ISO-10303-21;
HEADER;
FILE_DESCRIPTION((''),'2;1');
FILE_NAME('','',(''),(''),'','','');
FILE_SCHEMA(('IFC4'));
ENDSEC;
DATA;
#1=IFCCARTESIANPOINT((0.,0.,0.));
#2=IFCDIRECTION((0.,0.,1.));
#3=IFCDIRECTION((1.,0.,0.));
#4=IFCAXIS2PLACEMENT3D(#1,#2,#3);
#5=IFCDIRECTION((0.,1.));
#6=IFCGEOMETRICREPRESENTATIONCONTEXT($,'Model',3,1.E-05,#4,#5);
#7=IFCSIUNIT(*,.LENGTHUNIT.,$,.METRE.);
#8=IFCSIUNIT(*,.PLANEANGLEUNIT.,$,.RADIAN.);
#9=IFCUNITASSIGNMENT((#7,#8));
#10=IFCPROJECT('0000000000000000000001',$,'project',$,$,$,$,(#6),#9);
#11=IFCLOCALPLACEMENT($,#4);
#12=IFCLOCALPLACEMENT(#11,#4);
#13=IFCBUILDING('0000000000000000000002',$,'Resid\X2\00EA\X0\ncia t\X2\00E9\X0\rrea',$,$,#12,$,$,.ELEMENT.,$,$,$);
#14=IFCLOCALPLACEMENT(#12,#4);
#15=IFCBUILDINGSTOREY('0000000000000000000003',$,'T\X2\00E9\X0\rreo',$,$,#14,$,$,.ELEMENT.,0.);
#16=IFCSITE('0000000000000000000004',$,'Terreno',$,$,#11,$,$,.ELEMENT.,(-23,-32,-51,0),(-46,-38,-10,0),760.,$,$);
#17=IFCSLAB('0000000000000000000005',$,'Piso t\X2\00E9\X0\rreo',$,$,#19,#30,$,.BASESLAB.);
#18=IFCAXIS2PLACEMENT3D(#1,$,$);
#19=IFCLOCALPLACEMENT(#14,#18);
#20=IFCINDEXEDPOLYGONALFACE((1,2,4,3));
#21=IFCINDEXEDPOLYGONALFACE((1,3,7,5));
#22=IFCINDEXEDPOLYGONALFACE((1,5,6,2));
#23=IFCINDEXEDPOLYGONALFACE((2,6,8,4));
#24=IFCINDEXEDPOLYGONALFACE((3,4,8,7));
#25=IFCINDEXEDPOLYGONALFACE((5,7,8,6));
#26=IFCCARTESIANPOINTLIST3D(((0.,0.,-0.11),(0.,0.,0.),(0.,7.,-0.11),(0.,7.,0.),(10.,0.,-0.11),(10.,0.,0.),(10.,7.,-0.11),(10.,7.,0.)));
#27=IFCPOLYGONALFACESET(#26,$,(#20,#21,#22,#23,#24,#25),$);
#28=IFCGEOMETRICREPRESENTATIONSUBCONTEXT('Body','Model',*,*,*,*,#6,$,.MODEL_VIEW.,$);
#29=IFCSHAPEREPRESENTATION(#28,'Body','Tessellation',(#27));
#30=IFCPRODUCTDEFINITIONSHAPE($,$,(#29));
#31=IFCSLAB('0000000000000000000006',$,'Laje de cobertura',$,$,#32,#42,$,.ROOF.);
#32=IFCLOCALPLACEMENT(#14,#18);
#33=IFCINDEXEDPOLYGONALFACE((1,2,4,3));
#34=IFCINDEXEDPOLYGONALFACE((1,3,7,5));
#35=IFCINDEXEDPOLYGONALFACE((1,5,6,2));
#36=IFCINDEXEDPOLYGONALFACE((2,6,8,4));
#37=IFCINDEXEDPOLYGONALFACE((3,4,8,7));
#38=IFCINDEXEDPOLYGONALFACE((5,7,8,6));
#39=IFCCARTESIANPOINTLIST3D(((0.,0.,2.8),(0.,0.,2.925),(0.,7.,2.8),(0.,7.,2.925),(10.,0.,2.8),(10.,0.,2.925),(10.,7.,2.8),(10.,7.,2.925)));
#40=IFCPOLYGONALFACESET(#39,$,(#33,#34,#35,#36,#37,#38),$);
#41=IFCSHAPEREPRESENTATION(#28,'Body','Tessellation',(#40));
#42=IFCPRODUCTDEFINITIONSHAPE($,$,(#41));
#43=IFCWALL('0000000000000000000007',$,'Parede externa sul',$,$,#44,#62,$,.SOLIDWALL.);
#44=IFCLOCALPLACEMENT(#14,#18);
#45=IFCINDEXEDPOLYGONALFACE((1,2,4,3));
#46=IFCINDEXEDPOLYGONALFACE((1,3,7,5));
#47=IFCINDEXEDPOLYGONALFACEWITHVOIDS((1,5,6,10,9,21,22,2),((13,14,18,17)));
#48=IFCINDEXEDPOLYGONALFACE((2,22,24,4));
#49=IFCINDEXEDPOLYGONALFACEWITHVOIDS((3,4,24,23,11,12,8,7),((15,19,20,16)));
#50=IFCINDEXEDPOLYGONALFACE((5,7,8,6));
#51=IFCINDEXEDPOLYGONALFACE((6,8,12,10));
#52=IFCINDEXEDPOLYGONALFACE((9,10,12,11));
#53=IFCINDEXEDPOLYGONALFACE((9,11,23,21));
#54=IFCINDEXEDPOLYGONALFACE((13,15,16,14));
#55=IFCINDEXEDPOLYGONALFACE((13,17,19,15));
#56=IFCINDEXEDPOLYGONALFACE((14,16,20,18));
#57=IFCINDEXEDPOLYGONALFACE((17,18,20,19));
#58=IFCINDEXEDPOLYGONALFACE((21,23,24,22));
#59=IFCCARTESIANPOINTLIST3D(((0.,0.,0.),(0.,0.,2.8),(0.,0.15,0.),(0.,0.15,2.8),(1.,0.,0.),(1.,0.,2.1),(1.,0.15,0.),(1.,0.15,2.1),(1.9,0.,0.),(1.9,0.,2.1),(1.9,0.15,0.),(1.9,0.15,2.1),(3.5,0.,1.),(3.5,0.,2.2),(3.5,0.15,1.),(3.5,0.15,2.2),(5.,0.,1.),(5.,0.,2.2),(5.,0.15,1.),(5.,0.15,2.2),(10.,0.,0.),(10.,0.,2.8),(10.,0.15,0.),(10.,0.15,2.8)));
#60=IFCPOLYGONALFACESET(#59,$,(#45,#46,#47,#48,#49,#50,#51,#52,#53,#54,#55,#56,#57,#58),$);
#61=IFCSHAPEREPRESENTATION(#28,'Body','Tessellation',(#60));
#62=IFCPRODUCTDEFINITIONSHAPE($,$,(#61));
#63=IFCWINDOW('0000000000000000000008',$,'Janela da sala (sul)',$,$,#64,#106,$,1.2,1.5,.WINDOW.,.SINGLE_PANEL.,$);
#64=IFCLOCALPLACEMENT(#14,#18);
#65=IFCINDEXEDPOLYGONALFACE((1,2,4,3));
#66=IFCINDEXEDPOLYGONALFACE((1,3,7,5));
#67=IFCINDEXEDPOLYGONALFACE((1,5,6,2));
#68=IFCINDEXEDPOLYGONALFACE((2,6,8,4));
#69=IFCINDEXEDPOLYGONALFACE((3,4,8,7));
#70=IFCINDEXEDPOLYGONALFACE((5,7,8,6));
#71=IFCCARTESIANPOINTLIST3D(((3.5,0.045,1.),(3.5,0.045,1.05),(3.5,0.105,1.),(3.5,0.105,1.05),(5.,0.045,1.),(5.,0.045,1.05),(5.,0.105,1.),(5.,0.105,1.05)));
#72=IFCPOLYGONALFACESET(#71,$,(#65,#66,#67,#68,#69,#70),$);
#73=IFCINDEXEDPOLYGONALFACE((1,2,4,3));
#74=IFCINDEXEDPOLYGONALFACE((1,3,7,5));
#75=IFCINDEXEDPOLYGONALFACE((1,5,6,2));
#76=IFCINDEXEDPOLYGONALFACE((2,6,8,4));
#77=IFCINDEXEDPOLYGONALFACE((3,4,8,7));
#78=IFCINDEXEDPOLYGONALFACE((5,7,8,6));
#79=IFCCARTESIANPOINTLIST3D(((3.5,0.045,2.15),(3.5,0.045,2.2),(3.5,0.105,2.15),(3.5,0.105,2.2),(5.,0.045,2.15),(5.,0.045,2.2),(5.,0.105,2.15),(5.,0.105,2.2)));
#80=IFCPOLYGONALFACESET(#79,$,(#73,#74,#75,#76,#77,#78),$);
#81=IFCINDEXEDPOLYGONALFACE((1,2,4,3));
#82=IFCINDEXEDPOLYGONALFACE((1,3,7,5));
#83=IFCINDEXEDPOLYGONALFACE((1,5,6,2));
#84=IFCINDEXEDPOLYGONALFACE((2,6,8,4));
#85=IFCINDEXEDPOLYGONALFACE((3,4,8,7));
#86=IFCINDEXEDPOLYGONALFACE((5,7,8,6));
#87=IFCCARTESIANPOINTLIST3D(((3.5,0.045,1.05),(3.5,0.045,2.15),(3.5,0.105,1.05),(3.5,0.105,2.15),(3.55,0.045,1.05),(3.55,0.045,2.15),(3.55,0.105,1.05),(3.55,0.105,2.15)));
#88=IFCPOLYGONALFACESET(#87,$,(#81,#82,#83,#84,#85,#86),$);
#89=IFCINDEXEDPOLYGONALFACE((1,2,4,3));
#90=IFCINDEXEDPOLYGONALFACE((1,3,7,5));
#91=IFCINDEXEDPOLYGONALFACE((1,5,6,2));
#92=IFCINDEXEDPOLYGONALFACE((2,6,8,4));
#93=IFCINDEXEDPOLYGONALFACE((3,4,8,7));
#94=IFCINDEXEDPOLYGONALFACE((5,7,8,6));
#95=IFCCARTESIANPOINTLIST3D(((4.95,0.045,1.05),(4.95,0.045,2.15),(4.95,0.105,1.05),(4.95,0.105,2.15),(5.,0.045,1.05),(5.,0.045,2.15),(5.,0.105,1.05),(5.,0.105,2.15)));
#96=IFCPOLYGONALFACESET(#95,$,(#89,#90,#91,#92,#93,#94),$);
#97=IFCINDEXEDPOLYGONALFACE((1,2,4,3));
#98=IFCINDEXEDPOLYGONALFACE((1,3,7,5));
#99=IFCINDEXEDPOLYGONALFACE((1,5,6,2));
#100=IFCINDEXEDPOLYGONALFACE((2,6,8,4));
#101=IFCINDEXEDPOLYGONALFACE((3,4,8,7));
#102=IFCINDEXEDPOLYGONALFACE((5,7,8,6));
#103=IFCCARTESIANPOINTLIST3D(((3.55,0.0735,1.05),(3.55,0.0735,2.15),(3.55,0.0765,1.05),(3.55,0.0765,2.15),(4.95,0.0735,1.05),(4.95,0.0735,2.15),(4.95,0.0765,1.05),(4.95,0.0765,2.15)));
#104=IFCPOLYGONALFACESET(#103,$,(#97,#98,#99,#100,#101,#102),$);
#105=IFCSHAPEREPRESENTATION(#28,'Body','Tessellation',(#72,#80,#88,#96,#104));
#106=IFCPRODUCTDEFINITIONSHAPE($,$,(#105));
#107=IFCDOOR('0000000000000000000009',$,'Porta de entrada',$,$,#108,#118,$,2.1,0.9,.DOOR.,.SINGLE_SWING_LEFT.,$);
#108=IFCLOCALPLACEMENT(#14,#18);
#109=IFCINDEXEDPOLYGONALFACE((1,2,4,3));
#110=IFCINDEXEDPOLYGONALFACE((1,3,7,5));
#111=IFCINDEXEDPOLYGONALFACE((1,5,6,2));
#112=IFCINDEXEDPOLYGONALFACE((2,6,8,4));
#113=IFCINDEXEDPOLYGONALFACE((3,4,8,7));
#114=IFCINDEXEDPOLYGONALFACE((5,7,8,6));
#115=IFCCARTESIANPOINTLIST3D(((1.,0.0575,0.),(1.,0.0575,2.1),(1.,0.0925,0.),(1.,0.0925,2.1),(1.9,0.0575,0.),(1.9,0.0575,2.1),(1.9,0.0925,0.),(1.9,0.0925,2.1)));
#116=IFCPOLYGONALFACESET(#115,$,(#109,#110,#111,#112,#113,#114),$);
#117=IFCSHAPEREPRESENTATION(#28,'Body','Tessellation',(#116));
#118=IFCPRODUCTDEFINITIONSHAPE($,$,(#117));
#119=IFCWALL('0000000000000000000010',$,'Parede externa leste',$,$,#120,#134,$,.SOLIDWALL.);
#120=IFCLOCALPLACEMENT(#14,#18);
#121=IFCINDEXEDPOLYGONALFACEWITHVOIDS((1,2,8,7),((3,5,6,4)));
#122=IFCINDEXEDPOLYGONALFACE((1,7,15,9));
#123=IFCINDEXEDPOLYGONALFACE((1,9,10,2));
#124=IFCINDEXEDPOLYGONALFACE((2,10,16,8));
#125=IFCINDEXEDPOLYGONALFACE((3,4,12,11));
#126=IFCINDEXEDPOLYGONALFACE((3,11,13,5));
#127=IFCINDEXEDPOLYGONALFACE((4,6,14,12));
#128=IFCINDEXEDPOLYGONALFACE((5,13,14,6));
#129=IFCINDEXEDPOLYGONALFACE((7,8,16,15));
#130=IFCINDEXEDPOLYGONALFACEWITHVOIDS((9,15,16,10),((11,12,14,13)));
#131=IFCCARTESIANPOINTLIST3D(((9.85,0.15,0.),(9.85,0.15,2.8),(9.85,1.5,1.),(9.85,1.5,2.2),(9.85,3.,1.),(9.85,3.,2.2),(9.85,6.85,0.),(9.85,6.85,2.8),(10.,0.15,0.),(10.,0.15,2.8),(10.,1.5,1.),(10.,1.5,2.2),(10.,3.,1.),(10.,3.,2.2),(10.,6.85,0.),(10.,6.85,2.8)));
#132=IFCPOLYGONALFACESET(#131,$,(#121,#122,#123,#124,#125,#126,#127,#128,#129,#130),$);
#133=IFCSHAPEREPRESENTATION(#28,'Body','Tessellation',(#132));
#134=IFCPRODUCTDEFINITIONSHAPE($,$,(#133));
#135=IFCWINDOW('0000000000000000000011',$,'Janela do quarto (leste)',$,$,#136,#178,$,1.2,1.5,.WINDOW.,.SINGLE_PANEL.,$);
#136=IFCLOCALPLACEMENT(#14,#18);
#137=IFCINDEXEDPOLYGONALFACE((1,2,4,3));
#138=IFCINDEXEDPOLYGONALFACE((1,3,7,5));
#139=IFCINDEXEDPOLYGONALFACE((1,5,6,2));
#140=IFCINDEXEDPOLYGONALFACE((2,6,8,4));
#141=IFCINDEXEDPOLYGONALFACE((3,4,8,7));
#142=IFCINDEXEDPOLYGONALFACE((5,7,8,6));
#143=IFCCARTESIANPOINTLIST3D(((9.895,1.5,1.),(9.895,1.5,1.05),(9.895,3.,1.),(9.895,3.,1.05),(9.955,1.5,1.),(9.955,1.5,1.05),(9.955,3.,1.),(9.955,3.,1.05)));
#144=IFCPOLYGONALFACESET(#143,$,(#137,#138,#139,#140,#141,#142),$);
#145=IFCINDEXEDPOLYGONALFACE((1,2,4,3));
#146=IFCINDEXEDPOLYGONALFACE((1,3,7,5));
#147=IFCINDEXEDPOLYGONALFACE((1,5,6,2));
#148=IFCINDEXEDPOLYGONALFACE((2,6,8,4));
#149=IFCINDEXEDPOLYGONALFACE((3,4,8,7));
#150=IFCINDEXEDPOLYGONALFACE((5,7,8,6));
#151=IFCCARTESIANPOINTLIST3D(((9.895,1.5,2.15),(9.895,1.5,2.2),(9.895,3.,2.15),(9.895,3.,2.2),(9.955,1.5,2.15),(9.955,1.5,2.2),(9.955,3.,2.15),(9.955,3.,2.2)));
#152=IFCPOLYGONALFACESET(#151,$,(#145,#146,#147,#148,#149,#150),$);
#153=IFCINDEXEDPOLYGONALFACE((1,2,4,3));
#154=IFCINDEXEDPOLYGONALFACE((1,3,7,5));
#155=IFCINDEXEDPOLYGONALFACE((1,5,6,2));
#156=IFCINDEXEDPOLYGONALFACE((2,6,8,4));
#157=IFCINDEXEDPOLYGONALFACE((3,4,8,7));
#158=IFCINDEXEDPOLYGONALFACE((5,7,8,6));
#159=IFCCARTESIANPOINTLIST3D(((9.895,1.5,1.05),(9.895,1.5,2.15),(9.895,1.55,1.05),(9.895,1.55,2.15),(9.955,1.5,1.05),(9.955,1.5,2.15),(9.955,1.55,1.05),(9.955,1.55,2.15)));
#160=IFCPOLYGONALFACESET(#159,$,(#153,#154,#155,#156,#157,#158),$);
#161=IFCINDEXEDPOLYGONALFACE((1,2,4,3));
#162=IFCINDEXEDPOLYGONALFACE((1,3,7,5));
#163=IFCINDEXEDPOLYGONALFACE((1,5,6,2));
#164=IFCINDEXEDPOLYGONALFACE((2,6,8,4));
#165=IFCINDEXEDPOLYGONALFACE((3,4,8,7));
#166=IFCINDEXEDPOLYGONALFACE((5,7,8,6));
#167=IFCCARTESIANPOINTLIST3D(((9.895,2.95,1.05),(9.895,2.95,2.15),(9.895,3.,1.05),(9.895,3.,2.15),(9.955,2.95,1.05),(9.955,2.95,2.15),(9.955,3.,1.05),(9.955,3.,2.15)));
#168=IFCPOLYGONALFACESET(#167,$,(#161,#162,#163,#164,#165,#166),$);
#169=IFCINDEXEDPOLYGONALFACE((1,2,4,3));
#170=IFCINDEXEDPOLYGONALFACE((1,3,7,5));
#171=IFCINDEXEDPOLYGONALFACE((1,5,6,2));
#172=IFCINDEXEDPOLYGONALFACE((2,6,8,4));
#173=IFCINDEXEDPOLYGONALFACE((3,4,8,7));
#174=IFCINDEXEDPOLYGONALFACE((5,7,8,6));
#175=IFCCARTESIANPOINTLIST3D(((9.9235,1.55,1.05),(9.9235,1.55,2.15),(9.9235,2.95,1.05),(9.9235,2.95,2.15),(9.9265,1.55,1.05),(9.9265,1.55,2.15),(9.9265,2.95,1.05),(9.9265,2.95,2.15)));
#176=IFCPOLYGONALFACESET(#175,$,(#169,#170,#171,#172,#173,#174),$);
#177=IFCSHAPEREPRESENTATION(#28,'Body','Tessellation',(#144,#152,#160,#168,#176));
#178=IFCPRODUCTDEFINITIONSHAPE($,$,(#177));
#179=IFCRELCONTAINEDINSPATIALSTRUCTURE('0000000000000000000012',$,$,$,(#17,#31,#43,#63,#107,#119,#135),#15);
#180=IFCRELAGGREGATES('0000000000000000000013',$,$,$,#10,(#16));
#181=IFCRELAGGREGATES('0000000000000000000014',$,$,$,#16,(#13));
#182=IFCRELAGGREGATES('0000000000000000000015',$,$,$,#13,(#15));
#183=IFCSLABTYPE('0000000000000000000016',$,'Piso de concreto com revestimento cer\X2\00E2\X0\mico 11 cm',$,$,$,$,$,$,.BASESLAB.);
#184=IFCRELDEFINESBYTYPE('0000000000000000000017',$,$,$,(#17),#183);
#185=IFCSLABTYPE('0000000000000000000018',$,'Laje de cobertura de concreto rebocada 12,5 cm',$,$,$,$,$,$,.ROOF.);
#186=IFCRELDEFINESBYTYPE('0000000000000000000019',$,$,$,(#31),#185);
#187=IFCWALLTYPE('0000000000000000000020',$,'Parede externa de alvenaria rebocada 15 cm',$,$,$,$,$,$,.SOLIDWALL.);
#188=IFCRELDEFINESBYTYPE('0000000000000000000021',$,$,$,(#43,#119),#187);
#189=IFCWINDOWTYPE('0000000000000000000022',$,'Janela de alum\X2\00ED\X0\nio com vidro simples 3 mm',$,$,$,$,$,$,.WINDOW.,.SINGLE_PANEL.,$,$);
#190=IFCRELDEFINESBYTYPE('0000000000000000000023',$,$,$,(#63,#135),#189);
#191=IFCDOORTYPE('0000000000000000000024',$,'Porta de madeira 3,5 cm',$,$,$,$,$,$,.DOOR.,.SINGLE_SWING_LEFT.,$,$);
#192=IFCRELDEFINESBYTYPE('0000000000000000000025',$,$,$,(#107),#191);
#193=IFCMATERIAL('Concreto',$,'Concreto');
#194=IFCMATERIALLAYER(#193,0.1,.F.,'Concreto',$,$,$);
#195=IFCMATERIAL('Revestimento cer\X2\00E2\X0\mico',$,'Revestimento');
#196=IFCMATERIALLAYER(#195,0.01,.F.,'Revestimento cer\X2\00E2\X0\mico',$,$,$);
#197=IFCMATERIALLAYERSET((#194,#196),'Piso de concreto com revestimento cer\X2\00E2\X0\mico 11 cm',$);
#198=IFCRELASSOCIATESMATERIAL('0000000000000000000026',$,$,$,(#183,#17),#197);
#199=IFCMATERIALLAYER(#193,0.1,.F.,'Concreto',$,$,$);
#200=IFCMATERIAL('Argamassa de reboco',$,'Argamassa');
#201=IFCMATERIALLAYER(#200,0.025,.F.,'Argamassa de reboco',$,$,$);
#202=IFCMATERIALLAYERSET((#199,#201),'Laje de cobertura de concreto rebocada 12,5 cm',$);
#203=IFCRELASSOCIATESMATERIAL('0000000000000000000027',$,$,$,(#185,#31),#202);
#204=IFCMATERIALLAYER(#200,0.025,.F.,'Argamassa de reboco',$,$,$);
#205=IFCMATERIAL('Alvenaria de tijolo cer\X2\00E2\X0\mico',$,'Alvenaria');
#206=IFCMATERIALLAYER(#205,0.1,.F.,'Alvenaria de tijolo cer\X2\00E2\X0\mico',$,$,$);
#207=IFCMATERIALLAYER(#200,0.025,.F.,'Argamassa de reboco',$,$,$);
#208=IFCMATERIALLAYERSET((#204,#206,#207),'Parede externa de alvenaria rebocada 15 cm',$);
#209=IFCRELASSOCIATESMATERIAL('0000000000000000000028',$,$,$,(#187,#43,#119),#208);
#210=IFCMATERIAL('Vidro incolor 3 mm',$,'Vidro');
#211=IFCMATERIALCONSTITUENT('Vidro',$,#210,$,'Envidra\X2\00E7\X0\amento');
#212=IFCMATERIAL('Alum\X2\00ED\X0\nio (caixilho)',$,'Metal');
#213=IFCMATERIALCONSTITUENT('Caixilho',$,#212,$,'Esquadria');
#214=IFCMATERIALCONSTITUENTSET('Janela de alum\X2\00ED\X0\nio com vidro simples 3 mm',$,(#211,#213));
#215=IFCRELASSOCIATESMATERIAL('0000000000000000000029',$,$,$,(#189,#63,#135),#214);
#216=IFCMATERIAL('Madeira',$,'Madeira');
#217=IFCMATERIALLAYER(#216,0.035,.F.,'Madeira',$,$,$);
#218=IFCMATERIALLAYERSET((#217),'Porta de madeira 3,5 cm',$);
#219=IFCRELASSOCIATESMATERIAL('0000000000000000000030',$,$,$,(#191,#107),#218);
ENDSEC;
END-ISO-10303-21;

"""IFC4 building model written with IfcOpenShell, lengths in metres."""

from ifc_helpers import new_model, si_unit, direction, frame, frame_2d, origin_with_axes, place, context, subcontext, project, spatial, rectangle, extrude, material, layer, layer_set, layer_usage, constituent, constituent_set, type_object, element, fill, save


model = new_model("IFC4")

# Units and contexts
model_context = context("Model", 3, precision=1e-05, world=origin_with_axes(), true_north=direction((0.0, 1.0)))
body_context = subcontext(model_context, "Body", "Model", "MODEL_VIEW")
ifc_project = project(units=[si_unit("LENGTHUNIT", "METRE"), si_unit("PLANEANGLEUNIT", "RADIAN")], contexts=[model_context])

# Site, building, storey
site_placement = place(None, origin_with_axes())
site = spatial("IfcSite", under=ifc_project, at=site_placement, Name="Terreno", CompositionType="ELEMENT", RefLatitude=(-23, -32, -51, 0), RefLongitude=(-46, -38, -10, 0), RefElevation=760.0)
building_placement = place(site_placement, origin_with_axes())
building = spatial("IfcBuilding", under=site, at=building_placement, Name="Residência térrea", CompositionType="ELEMENT")
storey_placement = place(building_placement, origin_with_axes())
storey = spatial("IfcBuildingStorey", under=building, at=storey_placement, Name="Térreo", CompositionType="ELEMENT", Elevation=0.0)

# Slabs
ifc_material_1 = material(Name="Concreto", Category="Concreto")
ifc_layer_1 = layer(ifc_material_1, 0.1, ventilated=False, Name="Concreto")
ifc_material_2 = material(Name="Revestimento cerâmico", Category="Revestimento")
ifc_layer_2 = layer(ifc_material_2, 0.01, ventilated=False, Name="Revestimento cerâmico")
ifc_layer_set_1 = layer_set([ifc_layer_1, ifc_layer_2], Name="Piso de concreto com revestimento cerâmico 11 cm")
ifc_layer_usage_1 = layer_usage(ifc_layer_set_1, "AXIS3", "POSITIVE", 0.0)
slab_type_1 = type_object("IfcSlabType", Name="Piso de concreto com revestimento cerâmico 11 cm", PredefinedType="BASESLAB", material=ifc_layer_set_1)
slab_1_placement = place(storey_placement, origin_with_axes())
element("IfcSlab", 1, at=slab_1_placement, inside=storey, type_object=slab_type_1, material=ifc_layer_usage_1, Name="Piso térreo", PredefinedType="BASESLAB", context=body_context, shape_type="SweptSolid", body=[
    extrude(rectangle(XDim=10.0, YDim=7.0, at=frame_2d((5.0, 3.5))), frame((0.0, 0.0, -0.11), z_axis=(0.0, 0.0, 1.0), x_axis=(1.0, 0.0, 0.0)), (0.0, 0.0, 1.0), 0.11),
])
ifc_layer_3 = layer(ifc_material_1, 0.1, ventilated=False, Name="Concreto")
ifc_material_3 = material(Name="Argamassa de reboco", Category="Argamassa")
ifc_layer_4 = layer(ifc_material_3, 0.025, ventilated=False, Name="Argamassa de reboco")
ifc_layer_set_2 = layer_set([ifc_layer_3, ifc_layer_4], Name="Laje de cobertura de concreto rebocada 12,5 cm")
ifc_layer_usage_2 = layer_usage(ifc_layer_set_2, "AXIS3", "NEGATIVE", 0.0)
slab_type_2 = type_object("IfcSlabType", Name="Laje de cobertura de concreto rebocada 12,5 cm", PredefinedType="ROOF", material=ifc_layer_set_2)
slab_2_placement = place(storey_placement, origin_with_axes())
element("IfcSlab", 2, at=slab_2_placement, inside=storey, type_object=slab_type_2, material=ifc_layer_usage_2, Name="Laje de cobertura", PredefinedType="ROOF", context=body_context, shape_type="SweptSolid", body=[
    extrude(rectangle(XDim=10.0, YDim=7.0, at=frame_2d((5.0, 3.5))), frame((0.0, 0.0, 2.8), z_axis=(0.0, 0.0, 1.0), x_axis=(1.0, 0.0, 0.0)), (0.0, 0.0, 1.0), 0.125),
])

# Wall, openings, window, door
ifc_layer_5 = layer(ifc_material_3, 0.025, ventilated=False, Name="Argamassa de reboco")
ifc_material_4 = material(Name="Alvenaria de tijolo cerâmico", Category="Alvenaria")
ifc_layer_6 = layer(ifc_material_4, 0.1, ventilated=False, Name="Alvenaria de tijolo cerâmico")
ifc_layer_7 = layer(ifc_material_3, 0.025, ventilated=False, Name="Argamassa de reboco")
ifc_layer_set_3 = layer_set([ifc_layer_5, ifc_layer_6, ifc_layer_7], Name="Parede externa de alvenaria rebocada 15 cm")
ifc_layer_usage_3 = layer_usage(ifc_layer_set_3, "AXIS2", "POSITIVE", 0.0)
wall_type_1 = type_object("IfcWallType", Name="Parede externa de alvenaria rebocada 15 cm", PredefinedType="SOLIDWALL", material=ifc_layer_set_3)
wall_1_placement = place(storey_placement, origin_with_axes())
wall_1 = element("IfcWall", 3, at=wall_1_placement, inside=storey, type_object=wall_type_1, material=ifc_layer_usage_3, Name="Parede externa sul", PredefinedType="SOLIDWALL", context=body_context, shape_type="SweptSolid", body=[
    extrude(rectangle(XDim=10.0, YDim=0.15, at=frame_2d((5.0, 0.075))), origin_with_axes(), (0.0, 0.0, 1.0), 2.8),
])
opening_1_placement = place(wall_1_placement, frame((1.0, 0.0, 0.0), z_axis=(0.0, 0.0, 1.0), x_axis=(1.0, 0.0, 0.0)))
opening_1 = element("IfcOpeningElement", 4, at=opening_1_placement, cuts=wall_1, PredefinedType="OPENING", context=body_context, shape_type="SweptSolid", body=[
    extrude(rectangle(XDim=0.9, YDim=0.25, at=frame_2d((0.45, 0.075))), origin_with_axes(), (0.0, 0.0, 1.0), 2.1),
])
opening_2_placement = place(wall_1_placement, frame((3.5, 0.0, 1.0), z_axis=(0.0, 0.0, 1.0), x_axis=(1.0, 0.0, 0.0)))
opening_2 = element("IfcOpeningElement", 5, at=opening_2_placement, cuts=wall_1, PredefinedType="OPENING", context=body_context, shape_type="SweptSolid", body=[
    extrude(rectangle(XDim=1.5, YDim=0.25, at=frame_2d((0.75, 0.075))), origin_with_axes(), (0.0, 0.0, 1.0), 1.2),
])
ifc_material_5 = material(Name="Vidro incolor 3 mm", Category="Vidro")
ifc_constituent_1 = constituent(ifc_material_5, Name="Vidro", Category="Envidraçamento")
ifc_material_6 = material(Name="Alumínio (caixilho)", Category="Metal")
ifc_constituent_2 = constituent(ifc_material_6, Name="Caixilho", Category="Esquadria")
ifc_constituent_set = constituent_set(constituents=[ifc_constituent_1, ifc_constituent_2], Name="Janela de alumínio com vidro simples 3 mm")
window_type = type_object("IfcWindowType", Name="Janela de alumínio com vidro simples 3 mm", PartitioningType="SINGLE_PANEL", PredefinedType="WINDOW", material=ifc_constituent_set)
window_1_placement = place(opening_2_placement, origin_with_axes())
window_1 = element("IfcWindow", 6, at=window_1_placement, inside=storey, type_object=window_type, material=ifc_constituent_set, Name="Janela da sala (sul)", OverallHeight=1.2, OverallWidth=1.5, PartitioningType="SINGLE_PANEL", PredefinedType="WINDOW", context=body_context, shape_type="SweptSolid", body=[
    extrude(rectangle(XDim=1.5, YDim=0.06, at=frame_2d((0.75, 0.075))), origin_with_axes(), (0.0, 0.0, 1.0), 0.05),
    extrude(rectangle(XDim=1.5, YDim=0.06, at=frame_2d((0.75, 0.075))), frame((0.0, 0.0, 1.15), z_axis=(0.0, 0.0, 1.0), x_axis=(1.0, 0.0, 0.0)), (0.0, 0.0, 1.0), 0.05),
    extrude(rectangle(XDim=0.05, YDim=0.06, at=frame_2d((0.025, 0.075))), frame((0.0, 0.0, 0.05), z_axis=(0.0, 0.0, 1.0), x_axis=(1.0, 0.0, 0.0)), (0.0, 0.0, 1.0), 1.1),
    extrude(rectangle(XDim=0.05, YDim=0.06, at=frame_2d((1.475, 0.075))), frame((0.0, 0.0, 0.05), z_axis=(0.0, 0.0, 1.0), x_axis=(1.0, 0.0, 0.0)), (0.0, 0.0, 1.0), 1.1),
    extrude(rectangle(XDim=1.4, YDim=0.003, at=frame_2d((0.75, 0.075))), frame((0.0, 0.0, 0.05), z_axis=(0.0, 0.0, 1.0), x_axis=(1.0, 0.0, 0.0)), (0.0, 0.0, 1.0), 1.1),
])
fill(opening_2, window_1)
ifc_material_7 = material(Name="Madeira", Category="Madeira")
ifc_layer_8 = layer(ifc_material_7, 0.035, ventilated=False, Name="Madeira")
ifc_layer_set_4 = layer_set([ifc_layer_8], Name="Porta de madeira 3,5 cm")
door_type = type_object("IfcDoorType", Name="Porta de madeira 3,5 cm", OperationType="SINGLE_SWING_LEFT", PredefinedType="DOOR", material=ifc_layer_set_4)
door_1_placement = place(opening_1_placement, origin_with_axes())
door_1 = element("IfcDoor", 7, at=door_1_placement, inside=storey, type_object=door_type, material=ifc_layer_set_4, Name="Porta de entrada", OperationType="SINGLE_SWING_LEFT", OverallHeight=2.1, OverallWidth=0.9, PredefinedType="DOOR", context=body_context, shape_type="SweptSolid", body=[
    extrude(rectangle(XDim=0.9, YDim=0.035, at=frame_2d((0.45, 0.075))), origin_with_axes(), (0.0, 0.0, 1.0), 2.1),
])
fill(opening_1, door_1)

# Wall, opening, window
ifc_layer_usage_4 = layer_usage(ifc_layer_set_3, "AXIS2", "POSITIVE", 0.0)
wall_2_placement = place(storey_placement, frame((10.0, 0.15, 0.0), z_axis=(0.0, 0.0, 1.0), x_axis=(0.0, 1.0, 0.0)))
wall_2 = element("IfcWall", 8, at=wall_2_placement, inside=storey, type_object=wall_type_1, material=ifc_layer_usage_4, Name="Parede externa leste", PredefinedType="SOLIDWALL", context=body_context, shape_type="SweptSolid", body=[
    extrude(rectangle(XDim=6.7, YDim=0.15, at=frame_2d((3.35, 0.075))), origin_with_axes(), (0.0, 0.0, 1.0), 2.8),
])
opening_3_placement = place(wall_2_placement, frame((1.35, 0.0, 1.0), z_axis=(0.0, 0.0, 1.0), x_axis=(1.0, 0.0, 0.0)))
opening_3 = element("IfcOpeningElement", 9, at=opening_3_placement, cuts=wall_2, PredefinedType="OPENING", context=body_context, shape_type="SweptSolid", body=[
    extrude(rectangle(XDim=1.5, YDim=0.25, at=frame_2d((0.75, 0.075))), origin_with_axes(), (0.0, 0.0, 1.0), 1.2),
])
window_2_placement = place(opening_3_placement, origin_with_axes())
window_2 = element("IfcWindow", 10, at=window_2_placement, inside=storey, type_object=window_type, material=ifc_constituent_set, Name="Janela do quarto (leste)", OverallHeight=1.2, OverallWidth=1.5, PartitioningType="SINGLE_PANEL", PredefinedType="WINDOW", context=body_context, shape_type="SweptSolid", body=[
    extrude(rectangle(XDim=1.5, YDim=0.06, at=frame_2d((0.75, 0.075))), origin_with_axes(), (0.0, 0.0, 1.0), 0.05),
    extrude(rectangle(XDim=1.5, YDim=0.06, at=frame_2d((0.75, 0.075))), frame((0.0, 0.0, 1.15), z_axis=(0.0, 0.0, 1.0), x_axis=(1.0, 0.0, 0.0)), (0.0, 0.0, 1.0), 0.05),
    extrude(rectangle(XDim=0.05, YDim=0.06, at=frame_2d((0.025, 0.075))), frame((0.0, 0.0, 0.05), z_axis=(0.0, 0.0, 1.0), x_axis=(1.0, 0.0, 0.0)), (0.0, 0.0, 1.0), 1.1),
    extrude(rectangle(XDim=0.05, YDim=0.06, at=frame_2d((1.475, 0.075))), frame((0.0, 0.0, 0.05), z_axis=(0.0, 0.0, 1.0), x_axis=(1.0, 0.0, 0.0)), (0.0, 0.0, 1.0), 1.1),
    extrude(rectangle(XDim=1.4, YDim=0.003, at=frame_2d((0.75, 0.075))), frame((0.0, 0.0, 0.05), z_axis=(0.0, 0.0, 1.0), x_axis=(1.0, 0.0, 0.0)), (0.0, 0.0, 1.0), 1.1),
])
fill(opening_3, window_2)

save(model, "model.ifc")
